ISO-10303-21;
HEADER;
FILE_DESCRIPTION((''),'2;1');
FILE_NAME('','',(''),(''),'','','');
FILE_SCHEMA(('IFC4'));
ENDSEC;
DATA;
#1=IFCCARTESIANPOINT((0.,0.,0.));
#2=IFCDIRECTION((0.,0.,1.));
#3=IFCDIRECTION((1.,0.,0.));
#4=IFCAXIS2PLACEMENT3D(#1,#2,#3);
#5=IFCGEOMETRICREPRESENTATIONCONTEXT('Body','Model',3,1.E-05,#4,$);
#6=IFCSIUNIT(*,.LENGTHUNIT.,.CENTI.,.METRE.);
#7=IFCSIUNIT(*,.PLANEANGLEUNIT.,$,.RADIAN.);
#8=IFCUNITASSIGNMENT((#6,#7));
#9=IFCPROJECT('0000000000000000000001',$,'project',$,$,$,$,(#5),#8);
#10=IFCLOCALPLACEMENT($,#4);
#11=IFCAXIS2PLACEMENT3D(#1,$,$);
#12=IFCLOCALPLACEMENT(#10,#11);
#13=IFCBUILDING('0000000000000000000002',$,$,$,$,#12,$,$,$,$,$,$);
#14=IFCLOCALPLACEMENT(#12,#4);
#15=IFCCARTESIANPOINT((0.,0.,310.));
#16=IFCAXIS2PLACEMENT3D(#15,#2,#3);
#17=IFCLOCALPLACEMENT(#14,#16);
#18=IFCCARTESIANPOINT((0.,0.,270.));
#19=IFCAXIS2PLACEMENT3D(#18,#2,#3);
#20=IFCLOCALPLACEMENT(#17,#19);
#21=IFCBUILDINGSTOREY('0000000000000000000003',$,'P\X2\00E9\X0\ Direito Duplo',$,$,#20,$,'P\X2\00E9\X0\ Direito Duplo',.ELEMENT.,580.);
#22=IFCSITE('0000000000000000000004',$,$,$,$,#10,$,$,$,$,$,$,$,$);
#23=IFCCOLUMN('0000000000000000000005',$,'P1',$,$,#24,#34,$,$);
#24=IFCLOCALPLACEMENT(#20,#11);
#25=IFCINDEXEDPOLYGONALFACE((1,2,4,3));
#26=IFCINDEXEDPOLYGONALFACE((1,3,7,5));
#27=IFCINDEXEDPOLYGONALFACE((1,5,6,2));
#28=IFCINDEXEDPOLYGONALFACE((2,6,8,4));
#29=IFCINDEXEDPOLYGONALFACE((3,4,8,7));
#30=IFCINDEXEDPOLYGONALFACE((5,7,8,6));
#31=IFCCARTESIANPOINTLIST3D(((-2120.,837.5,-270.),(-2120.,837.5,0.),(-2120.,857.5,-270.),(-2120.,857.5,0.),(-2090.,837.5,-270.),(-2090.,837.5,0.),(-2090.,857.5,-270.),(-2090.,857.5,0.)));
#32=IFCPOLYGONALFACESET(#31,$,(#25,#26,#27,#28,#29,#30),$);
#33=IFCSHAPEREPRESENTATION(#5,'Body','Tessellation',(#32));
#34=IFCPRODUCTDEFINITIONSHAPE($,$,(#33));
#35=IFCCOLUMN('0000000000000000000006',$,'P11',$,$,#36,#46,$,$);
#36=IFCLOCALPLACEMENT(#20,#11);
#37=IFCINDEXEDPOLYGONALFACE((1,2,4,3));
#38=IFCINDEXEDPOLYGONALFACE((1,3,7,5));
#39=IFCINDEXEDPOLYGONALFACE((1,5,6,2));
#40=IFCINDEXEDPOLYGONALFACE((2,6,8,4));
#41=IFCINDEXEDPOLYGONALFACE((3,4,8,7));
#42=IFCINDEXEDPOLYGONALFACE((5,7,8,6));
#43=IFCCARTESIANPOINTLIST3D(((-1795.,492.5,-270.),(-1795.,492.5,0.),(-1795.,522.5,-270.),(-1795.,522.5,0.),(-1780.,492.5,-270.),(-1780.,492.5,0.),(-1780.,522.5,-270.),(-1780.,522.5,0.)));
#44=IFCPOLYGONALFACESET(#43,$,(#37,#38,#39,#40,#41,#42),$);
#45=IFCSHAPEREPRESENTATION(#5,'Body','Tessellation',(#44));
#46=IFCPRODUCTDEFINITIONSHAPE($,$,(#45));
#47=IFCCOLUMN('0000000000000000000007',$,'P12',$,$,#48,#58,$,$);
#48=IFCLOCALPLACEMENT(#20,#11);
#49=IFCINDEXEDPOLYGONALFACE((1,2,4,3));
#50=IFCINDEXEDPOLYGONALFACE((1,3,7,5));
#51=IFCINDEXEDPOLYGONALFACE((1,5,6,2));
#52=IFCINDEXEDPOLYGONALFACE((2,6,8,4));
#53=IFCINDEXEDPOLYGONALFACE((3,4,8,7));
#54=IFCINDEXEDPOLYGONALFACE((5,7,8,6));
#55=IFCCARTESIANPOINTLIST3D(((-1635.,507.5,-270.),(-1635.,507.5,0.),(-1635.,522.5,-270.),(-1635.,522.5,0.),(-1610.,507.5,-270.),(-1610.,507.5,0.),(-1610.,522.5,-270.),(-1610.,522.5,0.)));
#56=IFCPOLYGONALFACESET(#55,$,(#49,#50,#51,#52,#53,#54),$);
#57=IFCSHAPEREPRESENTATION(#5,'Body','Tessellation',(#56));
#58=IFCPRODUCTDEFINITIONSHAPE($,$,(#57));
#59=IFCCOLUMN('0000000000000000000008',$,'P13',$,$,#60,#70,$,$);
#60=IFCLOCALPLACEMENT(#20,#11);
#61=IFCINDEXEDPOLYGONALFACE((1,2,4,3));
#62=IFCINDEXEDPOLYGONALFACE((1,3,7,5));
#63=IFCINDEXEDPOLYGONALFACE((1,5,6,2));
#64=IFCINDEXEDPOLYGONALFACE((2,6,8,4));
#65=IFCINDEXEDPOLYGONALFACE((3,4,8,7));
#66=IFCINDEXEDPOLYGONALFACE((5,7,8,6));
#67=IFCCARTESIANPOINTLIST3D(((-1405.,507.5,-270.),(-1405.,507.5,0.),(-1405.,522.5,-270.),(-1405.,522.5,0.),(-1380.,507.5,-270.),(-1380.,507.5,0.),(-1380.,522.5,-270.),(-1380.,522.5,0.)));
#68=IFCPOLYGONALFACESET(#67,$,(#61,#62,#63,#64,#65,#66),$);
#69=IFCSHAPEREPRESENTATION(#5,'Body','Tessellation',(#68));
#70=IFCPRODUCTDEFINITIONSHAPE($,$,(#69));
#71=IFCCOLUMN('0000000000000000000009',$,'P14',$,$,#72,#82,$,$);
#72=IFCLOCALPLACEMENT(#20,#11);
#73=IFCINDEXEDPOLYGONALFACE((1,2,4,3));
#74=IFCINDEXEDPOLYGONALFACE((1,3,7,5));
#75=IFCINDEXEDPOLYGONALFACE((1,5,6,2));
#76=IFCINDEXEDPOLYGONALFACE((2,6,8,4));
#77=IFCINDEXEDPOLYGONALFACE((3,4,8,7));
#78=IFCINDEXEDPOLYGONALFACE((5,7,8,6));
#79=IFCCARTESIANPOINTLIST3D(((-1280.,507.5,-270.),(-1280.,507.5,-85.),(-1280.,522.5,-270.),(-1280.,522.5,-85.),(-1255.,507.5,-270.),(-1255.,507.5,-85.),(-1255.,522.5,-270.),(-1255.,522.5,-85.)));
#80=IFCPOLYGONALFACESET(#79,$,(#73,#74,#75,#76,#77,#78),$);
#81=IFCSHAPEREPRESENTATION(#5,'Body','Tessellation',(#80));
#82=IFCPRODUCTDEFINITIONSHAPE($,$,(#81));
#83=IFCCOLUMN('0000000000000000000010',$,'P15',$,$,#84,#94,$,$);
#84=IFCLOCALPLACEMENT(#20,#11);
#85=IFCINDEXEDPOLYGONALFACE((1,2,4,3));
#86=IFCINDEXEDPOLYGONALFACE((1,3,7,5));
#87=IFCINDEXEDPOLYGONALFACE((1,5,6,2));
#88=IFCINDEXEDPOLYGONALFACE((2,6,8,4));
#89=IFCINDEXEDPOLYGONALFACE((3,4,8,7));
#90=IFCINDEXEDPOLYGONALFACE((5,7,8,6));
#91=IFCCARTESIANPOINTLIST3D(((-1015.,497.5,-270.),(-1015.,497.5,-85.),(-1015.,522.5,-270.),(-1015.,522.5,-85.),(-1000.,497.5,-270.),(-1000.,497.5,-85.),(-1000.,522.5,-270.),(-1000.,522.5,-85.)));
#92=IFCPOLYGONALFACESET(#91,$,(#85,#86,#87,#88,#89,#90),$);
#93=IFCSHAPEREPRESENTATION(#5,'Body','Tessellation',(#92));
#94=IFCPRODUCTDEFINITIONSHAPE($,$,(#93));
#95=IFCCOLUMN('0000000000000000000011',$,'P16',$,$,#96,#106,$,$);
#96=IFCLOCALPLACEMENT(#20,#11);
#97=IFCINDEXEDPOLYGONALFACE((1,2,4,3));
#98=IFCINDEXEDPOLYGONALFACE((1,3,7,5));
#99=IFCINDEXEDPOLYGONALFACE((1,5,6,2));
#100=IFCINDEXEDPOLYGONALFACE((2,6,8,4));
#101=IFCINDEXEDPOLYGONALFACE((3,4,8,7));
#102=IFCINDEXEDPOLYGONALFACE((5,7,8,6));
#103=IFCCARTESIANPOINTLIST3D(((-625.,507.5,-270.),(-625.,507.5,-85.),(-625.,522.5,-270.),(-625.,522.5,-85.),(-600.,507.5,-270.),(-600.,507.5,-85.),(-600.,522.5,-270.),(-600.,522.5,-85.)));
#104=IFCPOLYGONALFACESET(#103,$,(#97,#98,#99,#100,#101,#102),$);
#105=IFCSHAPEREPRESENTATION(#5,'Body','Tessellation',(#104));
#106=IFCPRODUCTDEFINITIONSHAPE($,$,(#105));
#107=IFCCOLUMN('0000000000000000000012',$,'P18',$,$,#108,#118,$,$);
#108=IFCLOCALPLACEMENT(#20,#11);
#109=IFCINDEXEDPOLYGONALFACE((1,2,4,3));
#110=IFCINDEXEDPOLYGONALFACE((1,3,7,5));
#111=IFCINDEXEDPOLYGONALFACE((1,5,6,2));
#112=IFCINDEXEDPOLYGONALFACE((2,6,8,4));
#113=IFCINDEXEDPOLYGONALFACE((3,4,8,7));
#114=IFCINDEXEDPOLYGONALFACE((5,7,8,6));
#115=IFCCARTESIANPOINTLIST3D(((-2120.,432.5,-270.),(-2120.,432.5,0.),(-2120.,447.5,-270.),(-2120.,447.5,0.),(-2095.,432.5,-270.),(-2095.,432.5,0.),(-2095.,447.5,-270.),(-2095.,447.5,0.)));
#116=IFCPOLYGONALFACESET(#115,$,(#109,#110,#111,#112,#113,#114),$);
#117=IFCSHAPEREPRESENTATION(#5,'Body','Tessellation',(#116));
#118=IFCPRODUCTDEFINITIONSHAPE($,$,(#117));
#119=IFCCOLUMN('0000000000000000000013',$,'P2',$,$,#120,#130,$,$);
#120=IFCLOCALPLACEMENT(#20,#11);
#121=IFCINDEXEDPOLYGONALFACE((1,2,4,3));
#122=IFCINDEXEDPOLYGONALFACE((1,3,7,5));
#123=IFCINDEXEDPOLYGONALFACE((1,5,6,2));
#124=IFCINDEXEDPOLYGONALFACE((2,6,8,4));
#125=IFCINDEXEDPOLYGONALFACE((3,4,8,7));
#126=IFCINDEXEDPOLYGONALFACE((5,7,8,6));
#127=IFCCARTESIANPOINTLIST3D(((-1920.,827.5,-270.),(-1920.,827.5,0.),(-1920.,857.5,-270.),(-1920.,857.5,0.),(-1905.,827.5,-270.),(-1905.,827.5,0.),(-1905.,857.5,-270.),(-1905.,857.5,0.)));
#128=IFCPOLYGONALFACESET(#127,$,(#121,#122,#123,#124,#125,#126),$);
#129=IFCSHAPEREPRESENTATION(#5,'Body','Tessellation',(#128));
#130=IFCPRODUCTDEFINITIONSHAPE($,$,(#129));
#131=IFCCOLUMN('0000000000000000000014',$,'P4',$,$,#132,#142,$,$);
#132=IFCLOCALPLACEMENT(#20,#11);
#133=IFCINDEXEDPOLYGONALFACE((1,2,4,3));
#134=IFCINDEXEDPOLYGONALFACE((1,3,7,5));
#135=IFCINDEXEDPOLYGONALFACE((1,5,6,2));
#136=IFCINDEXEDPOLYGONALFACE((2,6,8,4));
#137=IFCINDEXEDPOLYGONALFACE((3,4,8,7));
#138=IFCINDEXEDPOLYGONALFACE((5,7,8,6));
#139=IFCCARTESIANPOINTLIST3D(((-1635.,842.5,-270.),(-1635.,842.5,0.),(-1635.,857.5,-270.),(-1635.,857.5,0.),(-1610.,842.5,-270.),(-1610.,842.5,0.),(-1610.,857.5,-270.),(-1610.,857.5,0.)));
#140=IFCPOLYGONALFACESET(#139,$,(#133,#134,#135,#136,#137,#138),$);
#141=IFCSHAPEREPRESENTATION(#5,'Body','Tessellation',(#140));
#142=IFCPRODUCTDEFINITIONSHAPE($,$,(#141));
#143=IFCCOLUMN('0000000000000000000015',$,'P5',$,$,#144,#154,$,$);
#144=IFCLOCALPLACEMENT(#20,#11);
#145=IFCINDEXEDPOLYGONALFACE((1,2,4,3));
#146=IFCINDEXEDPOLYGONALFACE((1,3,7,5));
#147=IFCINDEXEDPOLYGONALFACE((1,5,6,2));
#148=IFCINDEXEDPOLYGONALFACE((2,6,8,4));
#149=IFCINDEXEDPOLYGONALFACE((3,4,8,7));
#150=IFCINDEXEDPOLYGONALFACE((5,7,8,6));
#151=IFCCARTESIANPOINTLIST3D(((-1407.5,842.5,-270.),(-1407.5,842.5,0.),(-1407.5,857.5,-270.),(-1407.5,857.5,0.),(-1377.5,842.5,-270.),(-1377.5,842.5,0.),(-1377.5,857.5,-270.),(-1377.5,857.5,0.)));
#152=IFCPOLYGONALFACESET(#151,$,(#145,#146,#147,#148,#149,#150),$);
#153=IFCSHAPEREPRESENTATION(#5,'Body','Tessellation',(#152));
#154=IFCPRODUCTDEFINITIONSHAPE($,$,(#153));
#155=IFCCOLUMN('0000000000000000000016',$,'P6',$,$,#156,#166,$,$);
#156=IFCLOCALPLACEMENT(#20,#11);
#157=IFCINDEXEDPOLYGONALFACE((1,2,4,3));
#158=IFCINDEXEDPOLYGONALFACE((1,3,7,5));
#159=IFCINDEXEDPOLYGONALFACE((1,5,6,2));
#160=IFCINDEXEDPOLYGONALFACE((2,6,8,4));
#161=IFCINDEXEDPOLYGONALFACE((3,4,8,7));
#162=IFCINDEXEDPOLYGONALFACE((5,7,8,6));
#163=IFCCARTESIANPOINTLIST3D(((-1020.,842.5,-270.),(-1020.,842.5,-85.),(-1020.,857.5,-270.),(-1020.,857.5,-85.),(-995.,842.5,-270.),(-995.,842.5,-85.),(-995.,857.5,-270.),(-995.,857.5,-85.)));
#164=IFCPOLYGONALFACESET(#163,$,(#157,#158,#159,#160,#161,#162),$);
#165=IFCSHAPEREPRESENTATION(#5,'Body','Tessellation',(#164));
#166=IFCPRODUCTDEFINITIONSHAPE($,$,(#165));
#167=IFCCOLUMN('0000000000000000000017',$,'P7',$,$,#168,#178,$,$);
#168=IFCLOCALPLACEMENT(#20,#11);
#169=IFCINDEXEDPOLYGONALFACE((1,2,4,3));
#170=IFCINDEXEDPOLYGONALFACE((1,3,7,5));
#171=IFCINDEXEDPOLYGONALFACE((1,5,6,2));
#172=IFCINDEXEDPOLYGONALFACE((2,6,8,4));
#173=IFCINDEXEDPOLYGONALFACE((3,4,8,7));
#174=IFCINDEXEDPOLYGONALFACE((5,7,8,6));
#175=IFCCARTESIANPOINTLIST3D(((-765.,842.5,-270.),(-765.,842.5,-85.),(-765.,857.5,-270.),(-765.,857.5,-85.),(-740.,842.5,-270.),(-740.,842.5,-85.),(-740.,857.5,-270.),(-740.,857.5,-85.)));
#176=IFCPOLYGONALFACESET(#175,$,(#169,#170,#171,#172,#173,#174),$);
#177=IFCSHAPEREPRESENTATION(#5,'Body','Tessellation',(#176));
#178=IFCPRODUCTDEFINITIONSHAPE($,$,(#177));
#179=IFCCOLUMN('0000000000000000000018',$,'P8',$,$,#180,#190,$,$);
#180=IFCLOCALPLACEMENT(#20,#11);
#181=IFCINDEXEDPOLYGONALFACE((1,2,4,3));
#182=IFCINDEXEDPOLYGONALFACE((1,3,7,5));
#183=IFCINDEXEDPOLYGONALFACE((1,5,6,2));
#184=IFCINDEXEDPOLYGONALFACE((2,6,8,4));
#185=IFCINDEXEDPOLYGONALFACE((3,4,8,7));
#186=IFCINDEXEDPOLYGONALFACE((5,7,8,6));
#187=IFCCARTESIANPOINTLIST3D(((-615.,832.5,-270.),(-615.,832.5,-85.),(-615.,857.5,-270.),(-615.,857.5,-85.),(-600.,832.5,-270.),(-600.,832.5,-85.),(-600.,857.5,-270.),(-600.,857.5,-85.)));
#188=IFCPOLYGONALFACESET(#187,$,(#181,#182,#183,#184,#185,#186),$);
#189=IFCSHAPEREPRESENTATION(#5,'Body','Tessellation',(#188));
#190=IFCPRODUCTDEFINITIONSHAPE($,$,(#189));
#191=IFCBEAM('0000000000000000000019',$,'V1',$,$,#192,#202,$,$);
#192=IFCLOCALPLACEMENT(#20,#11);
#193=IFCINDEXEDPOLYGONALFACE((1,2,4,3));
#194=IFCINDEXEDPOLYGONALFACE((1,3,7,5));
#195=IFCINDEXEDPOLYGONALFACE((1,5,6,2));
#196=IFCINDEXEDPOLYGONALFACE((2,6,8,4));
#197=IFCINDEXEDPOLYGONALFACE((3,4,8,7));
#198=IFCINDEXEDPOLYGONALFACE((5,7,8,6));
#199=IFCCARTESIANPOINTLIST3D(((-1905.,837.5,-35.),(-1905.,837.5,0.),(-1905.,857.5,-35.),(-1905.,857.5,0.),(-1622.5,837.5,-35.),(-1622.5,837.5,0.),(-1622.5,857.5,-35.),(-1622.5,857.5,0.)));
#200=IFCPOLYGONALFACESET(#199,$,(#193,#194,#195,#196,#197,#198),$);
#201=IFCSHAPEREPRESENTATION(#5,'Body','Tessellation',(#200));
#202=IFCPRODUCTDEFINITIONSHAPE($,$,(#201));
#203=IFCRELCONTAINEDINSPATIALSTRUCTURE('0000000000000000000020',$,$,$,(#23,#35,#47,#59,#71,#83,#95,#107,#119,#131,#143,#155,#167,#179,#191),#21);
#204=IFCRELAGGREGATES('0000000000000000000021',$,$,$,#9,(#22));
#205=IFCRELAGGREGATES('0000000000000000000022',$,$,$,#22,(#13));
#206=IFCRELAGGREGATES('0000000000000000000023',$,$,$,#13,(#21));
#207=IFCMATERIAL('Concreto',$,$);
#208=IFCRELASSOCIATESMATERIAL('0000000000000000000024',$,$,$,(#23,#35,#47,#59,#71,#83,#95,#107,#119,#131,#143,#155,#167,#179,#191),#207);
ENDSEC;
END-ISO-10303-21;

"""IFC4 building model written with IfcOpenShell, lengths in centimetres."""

from ifc_helpers import new_model, si_unit, frame, origin, origin_with_axes, origin_2d_with_axis, place, context, project, spatial, rectangle, extrude, material, element, save


model = new_model("IFC4")

# Units and contexts
model_context = context("Model", 3, precision=1e-05, world=origin_with_axes(), identifier="Body")
ifc_project = project(units=[si_unit("LENGTHUNIT", "METRE", prefix="CENTI"), si_unit("PLANEANGLEUNIT", "RADIAN")], contexts=[model_context])

# Site, building, storey
site_placement = place(None, origin_with_axes())
site = spatial("IfcSite", under=ifc_project, at=site_placement)
building_placement = place(site_placement, origin())
building = spatial("IfcBuilding", under=site, at=building_placement)
placement_1 = place(building_placement, origin_with_axes())
placement_2 = place(placement_1, frame((0.0, 0.0, 310.0), z_axis=(0.0, 0.0, 1.0), x_axis=(1.0, 0.0, 0.0)))
storey_placement = place(placement_2, frame((0.0, 0.0, 270.0), z_axis=(0.0, 0.0, 1.0), x_axis=(1.0, 0.0, 0.0)))
storey = spatial("IfcBuildingStorey", under=building, at=storey_placement, Name="Pé Direito Duplo", LongName="Pé Direito Duplo", CompositionType="ELEMENT", Elevation=580.0)

# Columns
ifc_material = material(Name="Concreto")
column_1_placement = place(storey_placement, frame((-2105.0, 847.5, 0.0), z_axis=(0.0, 0.0, 1.0), x_axis=(1.0, 0.0, 0.0)))
element("IfcColumn", 1, at=column_1_placement, inside=storey, material=ifc_material, Name="P1", context=model_context, shape_type="SolidModel", body=[
    extrude(rectangle(XDim=20.0, YDim=30.0, at=origin_2d_with_axis()), frame((0.0, 0.0, 0.0), z_axis=(0.0, 0.0, 1.0), x_axis=(0.0, -1.0, 0.0)), (0.0, 0.0, -1.0), 270.0),
])
column_2_placement = place(storey_placement, frame((-1787.5, 507.5, 0.0), z_axis=(0.0, 0.0, 1.0), x_axis=(1.0, 0.0, 0.0)))
element("IfcColumn", 2, at=column_2_placement, inside=storey, material=ifc_material, Name="P11", context=model_context, shape_type="SolidModel", body=[
    extrude(rectangle(XDim=15.0, YDim=30.0, at=origin_2d_with_axis()), origin_with_axes(), (0.0, 0.0, -1.0), 270.0),
])
for number, where, z_axis, x_axis, name in (
    (3, (-1622.5, 515.0, 0.0), (0.0, 0.0, 1.0), (1.0, 0.0, 0.0), "P12"),
    (4, (-1392.5, 515.0, 0.0), (0.0, 0.0, 1.0), (1.0, 0.0, 0.0), "P13"),
):
    element("IfcColumn", number, at=place(storey_placement, frame(where, z_axis=z_axis, x_axis=x_axis)), inside=storey, material=ifc_material, Name=name, context=model_context, shape_type="SolidModel", body=[
        extrude(rectangle(XDim=15.0, YDim=25.0, at=origin_2d_with_axis()), frame((0.0, 0.0, 0.0), z_axis=(0.0, 0.0, 1.0), x_axis=(0.0, 1.0, 0.0)), (0.0, 0.0, -1.0), 270.0),
    ])
column_3_placement = place(storey_placement, frame((-1267.5, 515.0, -85.0), z_axis=(0.0, 0.0, 1.0), x_axis=(1.0, 0.0, 0.0)))
element("IfcColumn", 5, at=column_3_placement, inside=storey, material=ifc_material, Name="P14", context=model_context, shape_type="SolidModel", body=[
    extrude(rectangle(XDim=15.0, YDim=25.0, at=origin_2d_with_axis()), frame((0.0, 0.0, 0.0), z_axis=(0.0, 0.0, 1.0), x_axis=(0.0, 1.0, 0.0)), (0.0, 0.0, -1.0), 185.0),
])
column_4_placement = place(storey_placement, frame((-1007.5, 510.0, -85.0), z_axis=(0.0, 0.0, 1.0), x_axis=(1.0, 0.0, 0.0)))
element("IfcColumn", 6, at=column_4_placement, inside=storey, material=ifc_material, Name="P15", context=model_context, shape_type="SolidModel", body=[
    extrude(rectangle(XDim=15.0, YDim=25.0, at=origin_2d_with_axis()), origin_with_axes(), (0.0, 0.0, -1.0), 185.0),
])
column_5_placement = place(storey_placement, frame((-612.5, 515.0, -85.0), z_axis=(0.0, 0.0, 1.0), x_axis=(1.0, 0.0, 0.0)))
element("IfcColumn", 7, at=column_5_placement, inside=storey, material=ifc_material, Name="P16", context=model_context, shape_type="SolidModel", body=[
    extrude(rectangle(XDim=15.0, YDim=25.0, at=origin_2d_with_axis()), frame((0.0, 0.0, 0.0), z_axis=(0.0, 0.0, 1.0), x_axis=(0.0, -1.0, 0.0)), (0.0, 0.0, -1.0), 185.0),
])
column_6_placement = place(storey_placement, frame((-2107.5, 440.0, 0.0), z_axis=(0.0, 0.0, 1.0), x_axis=(1.0, 0.0, 0.0)))
element("IfcColumn", 8, at=column_6_placement, inside=storey, material=ifc_material, Name="P18", context=model_context, shape_type="SolidModel", body=[
    extrude(rectangle(XDim=15.0, YDim=25.0, at=origin_2d_with_axis()), frame((0.0, 0.0, 0.0), z_axis=(0.0, 0.0, 1.0), x_axis=(0.0, 1.0, 0.0)), (0.0, 0.0, -1.0), 270.0),
])
column_7_placement = place(storey_placement, frame((-1912.5, 842.5, 0.0), z_axis=(0.0, 0.0, 1.0), x_axis=(1.0, 0.0, 0.0)))
element("IfcColumn", 9, at=column_7_placement, inside=storey, material=ifc_material, Name="P2", context=model_context, shape_type="SolidModel", body=[
    extrude(rectangle(XDim=15.0, YDim=30.0, at=origin_2d_with_axis()), origin_with_axes(), (0.0, 0.0, -1.0), 270.0),
])
column_8_placement = place(storey_placement, frame((-1622.5, 850.0, 0.0), z_axis=(0.0, 0.0, 1.0), x_axis=(1.0, 0.0, 0.0)))
element("IfcColumn", 10, at=column_8_placement, inside=storey, material=ifc_material, Name="P4", context=model_context, shape_type="SolidModel", body=[
    extrude(rectangle(XDim=15.0, YDim=25.0, at=origin_2d_with_axis()), frame((0.0, 0.0, 0.0), z_axis=(0.0, 0.0, 1.0), x_axis=(0.0, -1.0, 0.0)), (0.0, 0.0, -1.0), 270.0),
])
column_9_placement = place(storey_placement, frame((-1392.5, 850.0, 0.0), z_axis=(0.0, 0.0, 1.0), x_axis=(1.0, 0.0, 0.0)))
element("IfcColumn", 11, at=column_9_placement, inside=storey, material=ifc_material, Name="P5", context=model_context, shape_type="SolidModel", body=[
    extrude(rectangle(XDim=15.0, YDim=30.0, at=origin_2d_with_axis()), frame((0.0, 0.0, 0.0), z_axis=(0.0, 0.0, 1.0), x_axis=(0.0, 1.0, 0.0)), (0.0, 0.0, -1.0), 270.0),
])
for number, where, z_axis, x_axis, name in (
    (12, (-1007.5, 850.0, -85.0), (0.0, 0.0, 1.0), (1.0, 0.0, 0.0), "P6"),
    (13, (-752.5, 850.0, -85.0), (0.0, 0.0, 1.0), (1.0, 0.0, 0.0), "P7"),
):
    element("IfcColumn", number, at=place(storey_placement, frame(where, z_axis=z_axis, x_axis=x_axis)), inside=storey, material=ifc_material, Name=name, context=model_context, shape_type="SolidModel", body=[
        extrude(rectangle(XDim=15.0, YDim=25.0, at=origin_2d_with_axis()), frame((0.0, 0.0, 0.0), z_axis=(0.0, 0.0, 1.0), x_axis=(0.0, 1.0, 0.0)), (0.0, 0.0, -1.0), 185.0),
    ])
column_10_placement = place(storey_placement, frame((-607.5, 845.0, -85.0), z_axis=(0.0, 0.0, 1.0), x_axis=(1.0, 0.0, 0.0)))
element("IfcColumn", 14, at=column_10_placement, inside=storey, material=ifc_material, Name="P8", context=model_context, shape_type="SolidModel", body=[
    extrude(rectangle(XDim=15.0, YDim=25.0, at=origin_2d_with_axis()), frame((0.0, 0.0, 0.0), z_axis=(0.0, 0.0, 1.0), x_axis=(-1.0, 0.0, 0.0)), (0.0, 0.0, -1.0), 185.0),
])

# Beam
beam_1_placement = place(storey_placement, frame((-1763.75, 847.5, 0.0), z_axis=(0.0, 0.0, 1.0), x_axis=(1.0, 0.0, 0.0)))
element("IfcBeam", 15, at=beam_1_placement, inside=storey, material=ifc_material, Name="V1", context=model_context, shape_type="SolidModel", body=[
    extrude(rectangle(XDim=20.0, YDim=35.0, at=origin_2d_with_axis()), frame((-141.25, 0.0, -17.5), z_axis=(1.0, 0.0, 0.0), x_axis=(0.0, -1.0, 0.0)), (0.0, 0.0, 1.0), 282.5),
])

save(model, "model.ifc")
